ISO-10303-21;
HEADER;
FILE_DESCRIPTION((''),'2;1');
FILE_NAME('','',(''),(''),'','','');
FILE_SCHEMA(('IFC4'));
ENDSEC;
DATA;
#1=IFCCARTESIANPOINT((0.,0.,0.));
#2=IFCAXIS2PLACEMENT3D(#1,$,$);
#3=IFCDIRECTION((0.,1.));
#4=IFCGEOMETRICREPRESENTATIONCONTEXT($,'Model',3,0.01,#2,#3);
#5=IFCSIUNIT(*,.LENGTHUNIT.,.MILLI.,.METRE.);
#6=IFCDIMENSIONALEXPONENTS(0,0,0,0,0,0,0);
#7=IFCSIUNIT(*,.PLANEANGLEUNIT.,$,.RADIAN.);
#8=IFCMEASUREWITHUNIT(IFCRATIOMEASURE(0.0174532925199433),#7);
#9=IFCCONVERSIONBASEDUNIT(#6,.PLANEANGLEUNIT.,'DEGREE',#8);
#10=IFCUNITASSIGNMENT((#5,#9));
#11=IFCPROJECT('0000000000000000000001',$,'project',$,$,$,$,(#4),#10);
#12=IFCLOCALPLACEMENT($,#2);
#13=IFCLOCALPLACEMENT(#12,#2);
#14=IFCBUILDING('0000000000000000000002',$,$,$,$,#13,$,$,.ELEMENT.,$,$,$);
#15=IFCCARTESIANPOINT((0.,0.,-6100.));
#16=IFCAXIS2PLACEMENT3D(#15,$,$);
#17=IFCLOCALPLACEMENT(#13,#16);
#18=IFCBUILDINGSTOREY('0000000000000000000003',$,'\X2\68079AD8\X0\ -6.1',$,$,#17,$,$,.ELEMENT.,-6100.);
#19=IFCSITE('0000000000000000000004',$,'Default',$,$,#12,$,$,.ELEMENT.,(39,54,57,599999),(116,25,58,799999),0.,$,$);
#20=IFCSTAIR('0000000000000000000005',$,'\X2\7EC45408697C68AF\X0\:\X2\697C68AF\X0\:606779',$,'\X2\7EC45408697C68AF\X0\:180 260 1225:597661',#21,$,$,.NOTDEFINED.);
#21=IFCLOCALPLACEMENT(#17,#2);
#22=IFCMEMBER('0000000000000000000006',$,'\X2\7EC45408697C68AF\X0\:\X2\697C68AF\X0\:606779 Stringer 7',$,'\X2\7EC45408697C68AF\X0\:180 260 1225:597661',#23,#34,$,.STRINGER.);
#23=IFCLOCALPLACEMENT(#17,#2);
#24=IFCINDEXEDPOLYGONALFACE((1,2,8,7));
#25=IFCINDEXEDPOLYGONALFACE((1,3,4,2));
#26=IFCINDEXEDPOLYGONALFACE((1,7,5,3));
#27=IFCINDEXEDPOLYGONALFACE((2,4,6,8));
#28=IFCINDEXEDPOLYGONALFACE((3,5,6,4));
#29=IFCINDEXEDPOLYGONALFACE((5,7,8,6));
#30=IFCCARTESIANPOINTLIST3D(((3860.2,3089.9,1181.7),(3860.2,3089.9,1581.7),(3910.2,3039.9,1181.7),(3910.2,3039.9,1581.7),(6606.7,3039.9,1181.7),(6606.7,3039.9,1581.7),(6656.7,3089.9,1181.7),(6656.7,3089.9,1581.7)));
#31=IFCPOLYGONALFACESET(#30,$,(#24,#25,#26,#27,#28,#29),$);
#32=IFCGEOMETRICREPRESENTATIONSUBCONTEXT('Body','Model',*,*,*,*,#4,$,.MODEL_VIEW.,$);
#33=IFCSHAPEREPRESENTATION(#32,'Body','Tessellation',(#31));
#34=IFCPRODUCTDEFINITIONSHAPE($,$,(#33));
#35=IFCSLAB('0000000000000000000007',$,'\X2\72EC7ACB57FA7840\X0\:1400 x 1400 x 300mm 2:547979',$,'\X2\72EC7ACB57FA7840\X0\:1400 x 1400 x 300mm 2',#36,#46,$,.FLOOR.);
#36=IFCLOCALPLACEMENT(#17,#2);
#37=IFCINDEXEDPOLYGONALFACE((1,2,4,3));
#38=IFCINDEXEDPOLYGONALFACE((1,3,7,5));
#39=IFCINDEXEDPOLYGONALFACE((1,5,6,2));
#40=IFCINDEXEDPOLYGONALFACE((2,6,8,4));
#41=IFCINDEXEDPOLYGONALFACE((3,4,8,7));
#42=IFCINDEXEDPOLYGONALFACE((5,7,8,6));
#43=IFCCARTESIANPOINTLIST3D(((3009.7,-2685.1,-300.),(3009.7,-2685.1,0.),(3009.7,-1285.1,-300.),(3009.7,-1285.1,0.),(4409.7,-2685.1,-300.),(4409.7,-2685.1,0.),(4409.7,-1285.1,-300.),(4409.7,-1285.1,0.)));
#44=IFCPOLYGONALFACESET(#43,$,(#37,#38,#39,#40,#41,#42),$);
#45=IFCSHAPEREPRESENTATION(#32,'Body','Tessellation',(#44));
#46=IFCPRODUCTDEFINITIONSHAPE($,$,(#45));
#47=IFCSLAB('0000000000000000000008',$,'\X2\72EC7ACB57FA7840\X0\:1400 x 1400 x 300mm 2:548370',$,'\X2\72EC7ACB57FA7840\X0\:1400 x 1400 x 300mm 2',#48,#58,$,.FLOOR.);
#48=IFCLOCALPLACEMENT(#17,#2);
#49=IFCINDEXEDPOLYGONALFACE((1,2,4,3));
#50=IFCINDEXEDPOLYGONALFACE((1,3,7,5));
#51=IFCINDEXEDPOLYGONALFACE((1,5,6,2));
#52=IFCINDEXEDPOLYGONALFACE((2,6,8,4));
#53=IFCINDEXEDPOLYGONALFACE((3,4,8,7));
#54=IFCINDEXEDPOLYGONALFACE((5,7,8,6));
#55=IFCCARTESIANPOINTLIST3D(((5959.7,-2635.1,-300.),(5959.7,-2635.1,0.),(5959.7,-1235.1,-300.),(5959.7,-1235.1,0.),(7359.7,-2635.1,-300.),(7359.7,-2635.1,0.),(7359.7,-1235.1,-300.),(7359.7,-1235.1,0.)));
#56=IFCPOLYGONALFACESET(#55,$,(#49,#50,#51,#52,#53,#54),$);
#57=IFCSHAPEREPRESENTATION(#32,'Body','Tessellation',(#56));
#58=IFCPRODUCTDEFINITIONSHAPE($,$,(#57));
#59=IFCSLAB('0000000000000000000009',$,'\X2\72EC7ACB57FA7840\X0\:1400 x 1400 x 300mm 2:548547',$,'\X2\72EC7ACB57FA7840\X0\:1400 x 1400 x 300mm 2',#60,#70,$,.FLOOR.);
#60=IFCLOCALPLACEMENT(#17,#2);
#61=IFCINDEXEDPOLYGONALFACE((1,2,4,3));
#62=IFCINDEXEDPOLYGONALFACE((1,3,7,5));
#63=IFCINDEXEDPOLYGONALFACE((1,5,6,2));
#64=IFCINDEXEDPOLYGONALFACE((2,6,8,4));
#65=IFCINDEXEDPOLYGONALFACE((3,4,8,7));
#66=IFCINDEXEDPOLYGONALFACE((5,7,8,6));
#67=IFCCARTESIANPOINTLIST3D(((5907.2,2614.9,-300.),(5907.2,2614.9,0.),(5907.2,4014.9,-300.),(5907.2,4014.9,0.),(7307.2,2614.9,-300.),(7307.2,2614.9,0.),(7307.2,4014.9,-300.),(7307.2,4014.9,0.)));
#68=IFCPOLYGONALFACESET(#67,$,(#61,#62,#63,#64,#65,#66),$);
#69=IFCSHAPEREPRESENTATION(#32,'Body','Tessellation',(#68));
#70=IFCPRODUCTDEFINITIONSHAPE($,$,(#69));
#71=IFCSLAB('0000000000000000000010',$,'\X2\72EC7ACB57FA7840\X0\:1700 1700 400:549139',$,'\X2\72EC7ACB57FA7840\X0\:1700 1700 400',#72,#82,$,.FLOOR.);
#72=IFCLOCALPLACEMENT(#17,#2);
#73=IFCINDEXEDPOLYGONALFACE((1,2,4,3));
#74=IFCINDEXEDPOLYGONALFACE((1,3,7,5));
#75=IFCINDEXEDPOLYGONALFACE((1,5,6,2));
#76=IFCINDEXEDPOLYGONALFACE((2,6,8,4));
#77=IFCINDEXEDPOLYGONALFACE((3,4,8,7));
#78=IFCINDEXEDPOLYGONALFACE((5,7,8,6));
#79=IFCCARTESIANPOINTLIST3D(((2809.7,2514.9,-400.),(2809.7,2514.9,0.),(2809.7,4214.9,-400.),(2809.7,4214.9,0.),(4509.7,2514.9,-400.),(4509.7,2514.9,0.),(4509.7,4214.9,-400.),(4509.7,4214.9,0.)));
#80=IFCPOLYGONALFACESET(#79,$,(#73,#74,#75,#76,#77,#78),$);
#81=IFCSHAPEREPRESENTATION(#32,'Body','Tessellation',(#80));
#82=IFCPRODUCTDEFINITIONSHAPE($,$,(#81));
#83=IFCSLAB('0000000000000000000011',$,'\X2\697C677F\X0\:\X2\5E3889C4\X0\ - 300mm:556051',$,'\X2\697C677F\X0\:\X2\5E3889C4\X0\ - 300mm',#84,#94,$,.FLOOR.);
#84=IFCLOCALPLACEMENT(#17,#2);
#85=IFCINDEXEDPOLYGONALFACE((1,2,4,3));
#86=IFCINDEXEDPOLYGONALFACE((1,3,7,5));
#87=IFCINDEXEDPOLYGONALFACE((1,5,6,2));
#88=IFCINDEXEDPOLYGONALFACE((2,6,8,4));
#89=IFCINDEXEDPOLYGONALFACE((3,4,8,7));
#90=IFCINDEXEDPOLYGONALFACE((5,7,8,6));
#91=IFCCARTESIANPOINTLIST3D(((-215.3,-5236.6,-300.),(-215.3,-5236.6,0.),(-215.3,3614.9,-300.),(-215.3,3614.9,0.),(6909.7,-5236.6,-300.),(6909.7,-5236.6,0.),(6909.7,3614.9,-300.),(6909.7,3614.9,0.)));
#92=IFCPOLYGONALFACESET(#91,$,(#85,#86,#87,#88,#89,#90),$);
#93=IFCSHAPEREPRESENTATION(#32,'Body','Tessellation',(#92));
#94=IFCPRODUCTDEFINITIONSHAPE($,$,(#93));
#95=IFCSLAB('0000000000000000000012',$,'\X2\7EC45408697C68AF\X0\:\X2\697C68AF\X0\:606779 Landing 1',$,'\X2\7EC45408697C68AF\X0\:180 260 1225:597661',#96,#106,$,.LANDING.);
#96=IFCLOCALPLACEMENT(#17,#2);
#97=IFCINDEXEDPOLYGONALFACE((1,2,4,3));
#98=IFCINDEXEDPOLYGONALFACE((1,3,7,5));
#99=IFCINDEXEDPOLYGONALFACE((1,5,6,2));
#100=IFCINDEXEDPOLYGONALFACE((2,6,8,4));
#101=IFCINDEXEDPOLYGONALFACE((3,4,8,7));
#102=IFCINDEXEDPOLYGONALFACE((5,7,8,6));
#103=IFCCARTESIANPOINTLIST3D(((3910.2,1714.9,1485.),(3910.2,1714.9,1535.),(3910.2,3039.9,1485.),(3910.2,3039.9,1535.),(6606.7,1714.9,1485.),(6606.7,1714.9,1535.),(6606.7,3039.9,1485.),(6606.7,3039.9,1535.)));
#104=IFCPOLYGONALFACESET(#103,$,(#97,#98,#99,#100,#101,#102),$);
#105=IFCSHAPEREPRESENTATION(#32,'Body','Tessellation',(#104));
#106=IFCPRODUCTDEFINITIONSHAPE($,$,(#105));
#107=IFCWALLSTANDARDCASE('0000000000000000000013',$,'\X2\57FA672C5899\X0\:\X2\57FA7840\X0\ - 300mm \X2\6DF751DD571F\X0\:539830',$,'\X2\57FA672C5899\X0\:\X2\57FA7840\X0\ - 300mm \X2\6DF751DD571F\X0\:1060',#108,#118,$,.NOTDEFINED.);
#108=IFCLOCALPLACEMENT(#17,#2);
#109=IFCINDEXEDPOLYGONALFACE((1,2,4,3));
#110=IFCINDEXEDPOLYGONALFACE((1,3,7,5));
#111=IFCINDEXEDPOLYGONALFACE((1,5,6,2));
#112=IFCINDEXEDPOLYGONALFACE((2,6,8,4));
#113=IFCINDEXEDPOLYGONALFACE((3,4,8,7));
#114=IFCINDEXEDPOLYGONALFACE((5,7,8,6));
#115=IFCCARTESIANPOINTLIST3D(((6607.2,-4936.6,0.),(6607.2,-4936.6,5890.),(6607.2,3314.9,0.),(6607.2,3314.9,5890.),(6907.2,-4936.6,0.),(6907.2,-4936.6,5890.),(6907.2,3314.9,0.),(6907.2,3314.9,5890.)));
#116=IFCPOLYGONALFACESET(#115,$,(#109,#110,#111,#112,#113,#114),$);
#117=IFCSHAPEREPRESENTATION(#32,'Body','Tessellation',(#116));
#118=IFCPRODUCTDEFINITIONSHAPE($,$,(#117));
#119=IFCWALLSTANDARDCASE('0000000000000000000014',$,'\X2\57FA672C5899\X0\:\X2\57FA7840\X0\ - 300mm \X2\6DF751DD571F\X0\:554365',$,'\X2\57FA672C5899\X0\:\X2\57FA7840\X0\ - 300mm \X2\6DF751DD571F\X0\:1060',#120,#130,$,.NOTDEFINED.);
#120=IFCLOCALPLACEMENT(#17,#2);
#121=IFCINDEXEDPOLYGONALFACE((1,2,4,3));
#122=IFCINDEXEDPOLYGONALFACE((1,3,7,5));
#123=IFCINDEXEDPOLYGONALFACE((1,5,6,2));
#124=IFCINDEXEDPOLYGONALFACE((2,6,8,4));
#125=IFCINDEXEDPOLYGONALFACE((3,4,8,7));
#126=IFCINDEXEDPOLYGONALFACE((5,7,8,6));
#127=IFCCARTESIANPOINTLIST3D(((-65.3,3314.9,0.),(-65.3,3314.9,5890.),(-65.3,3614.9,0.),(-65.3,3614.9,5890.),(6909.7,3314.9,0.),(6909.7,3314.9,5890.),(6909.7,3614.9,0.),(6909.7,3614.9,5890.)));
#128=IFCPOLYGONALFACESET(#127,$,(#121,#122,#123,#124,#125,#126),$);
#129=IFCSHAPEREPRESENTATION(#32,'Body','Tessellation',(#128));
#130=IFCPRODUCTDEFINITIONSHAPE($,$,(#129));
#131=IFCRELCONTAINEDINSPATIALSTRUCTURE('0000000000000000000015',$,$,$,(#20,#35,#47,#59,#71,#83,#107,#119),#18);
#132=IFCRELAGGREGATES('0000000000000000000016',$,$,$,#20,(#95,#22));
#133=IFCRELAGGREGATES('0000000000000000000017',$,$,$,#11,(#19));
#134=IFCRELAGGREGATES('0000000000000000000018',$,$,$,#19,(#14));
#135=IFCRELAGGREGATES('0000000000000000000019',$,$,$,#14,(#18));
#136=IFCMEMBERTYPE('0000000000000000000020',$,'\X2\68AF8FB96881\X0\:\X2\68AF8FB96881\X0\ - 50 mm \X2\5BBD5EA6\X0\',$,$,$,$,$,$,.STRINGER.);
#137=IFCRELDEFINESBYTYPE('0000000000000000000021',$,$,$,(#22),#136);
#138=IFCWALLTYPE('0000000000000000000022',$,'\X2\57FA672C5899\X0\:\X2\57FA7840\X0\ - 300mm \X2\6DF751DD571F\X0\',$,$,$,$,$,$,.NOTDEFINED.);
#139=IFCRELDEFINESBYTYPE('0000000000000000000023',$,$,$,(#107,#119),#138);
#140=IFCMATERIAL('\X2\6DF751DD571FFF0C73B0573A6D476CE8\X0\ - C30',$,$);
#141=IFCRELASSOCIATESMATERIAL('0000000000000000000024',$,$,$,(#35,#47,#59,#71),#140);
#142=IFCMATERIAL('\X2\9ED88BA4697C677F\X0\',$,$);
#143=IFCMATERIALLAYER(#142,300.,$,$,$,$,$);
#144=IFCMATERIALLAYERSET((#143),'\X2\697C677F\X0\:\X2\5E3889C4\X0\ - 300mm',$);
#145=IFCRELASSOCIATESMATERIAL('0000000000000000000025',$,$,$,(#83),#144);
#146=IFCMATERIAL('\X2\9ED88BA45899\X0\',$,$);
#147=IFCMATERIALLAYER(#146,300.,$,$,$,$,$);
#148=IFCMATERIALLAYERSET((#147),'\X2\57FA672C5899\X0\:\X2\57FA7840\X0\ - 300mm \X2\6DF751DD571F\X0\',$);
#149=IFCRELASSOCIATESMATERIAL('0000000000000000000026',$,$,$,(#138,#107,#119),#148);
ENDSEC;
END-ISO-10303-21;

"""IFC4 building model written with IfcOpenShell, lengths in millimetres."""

from ifc_helpers import new_model, entity, si_unit, converted_unit, direction, frame, frame_2d, origin, origin_2d_with_axis, place, context, subcontext, project, spatial, polyline, rectangle, outline, extrude, clip, bounded_halfspace, material, layer, layer_set, layer_usage, type_object, element, aggregate, save


model = new_model("IFC4")

# Units and contexts
model_context = context("Model", 3, precision=0.01, world=origin(), true_north=direction((0.0, 1.0)))
body_context = subcontext(model_context, "Body", "Model", "MODEL_VIEW")
ifc_project = project(units=[si_unit("LENGTHUNIT", "METRE", prefix="MILLI"), converted_unit("PLANEANGLEUNIT", "DEGREE", entity("IfcRatioMeasure", 0.0174532925199433), si_unit("PLANEANGLEUNIT", "RADIAN"), dimensions=[0, 0, 0, 0, 0, 0, 0])], contexts=[model_context])

# Site, building, storey
site_placement = place(None, origin())
site = spatial("IfcSite", under=ifc_project, at=site_placement, Name="Default", CompositionType="ELEMENT", RefLatitude=(39, 54, 57, 599999), RefLongitude=(116, 25, 58, 799999), RefElevation=0.0)
building_placement = place(site_placement, origin())
building = spatial("IfcBuilding", under=site, at=building_placement, CompositionType="ELEMENT")
storey_placement = place(building_placement, frame((0.0, 0.0, -6100.0)))
storey = spatial("IfcBuildingStorey", under=building, at=storey_placement, Name="标高 -6.1", CompositionType="ELEMENT", Elevation=-6100.0)

# Stair, member
stair_placement = place(storey_placement, origin())
stair = element("IfcStair", 1, at=stair_placement, inside=storey, Name="组合楼梯:楼梯:606779", ObjectType="组合楼梯:180 260 1225:597661", PredefinedType="NOTDEFINED")
member_type = type_object("IfcMemberType", Name="梯边梁:梯边梁 - 50 mm 宽度", PredefinedType="STRINGER")
member_1_placement = place(stair_placement, frame((3860.2, 3039.9, 1181.7)))
member_1 = element("IfcMember", 2, at=member_1_placement, type_object=member_type, Name="组合楼梯:楼梯:606779 Stringer 7", ObjectType="组合楼梯:180 260 1225:597661", PredefinedType="STRINGER", context=body_context, shape_type="SweptSolid", body=[
    extrude(outline(polyline([(-1398.3, -25.0), (1398.3, -25.0), (1348.3, 25.0), (-1348.3, 25.0), (-1398.3, -25.0)])), frame((1398.3, 25.0, 0.0), z_axis=(0.0, 0.0, 1.0), x_axis=(-1.0, 0.0, 0.0)), (0.0, 0.0, 1.0), 400.0),
])

# Slabs
ifc_material_1 = material(Name="混凝土，现场浇注 - C30")
for number, where, name in (
    (3, (3009.7, -2685.1, -300.0), "独立基础:1400 x 1400 x 300mm 2:547979"),
    (4, (5959.7, -2635.1, -300.0), "独立基础:1400 x 1400 x 300mm 2:548370"),
    (5, (5907.2, 2614.9, -300.0), "独立基础:1400 x 1400 x 300mm 2:548547"),
):
    element("IfcSlab", number, at=place(storey_placement, frame(where)), inside=storey, material=ifc_material_1, Name=name, ObjectType="独立基础:1400 x 1400 x 300mm 2", PredefinedType="FLOOR", context=body_context, shape_type="SweptSolid", body=[
        extrude(rectangle(XDim=1400.0, YDim=1400.0, at=origin_2d_with_axis()), frame((700.0, 700.0, 0.0), z_axis=(0.0, 0.0, 1.0), x_axis=(-1.0, 0.0, 0.0)), (0.0, 0.0, 1.0), 300.0),
    ])
slab_1_placement = place(storey_placement, frame((2809.7, 2514.9, -400.0)))
element("IfcSlab", 6, at=slab_1_placement, inside=storey, material=ifc_material_1, Name="独立基础:1700 1700 400:549139", ObjectType="独立基础:1700 1700 400", PredefinedType="FLOOR", context=body_context, shape_type="SweptSolid", body=[
    extrude(rectangle(XDim=1700.0, YDim=1700.0, at=frame_2d((0.0, 0.0), x_axis=(1.0, 0.0))), frame((850.0, 850.0, 0.0), z_axis=(0.0, 0.0, 1.0), x_axis=(-1.0, 0.0, 0.0)), (0.0, 0.0, 1.0), 400.0),
])
ifc_material_2 = material(Name="默认楼板")
ifc_layer_1 = layer(ifc_material_2, 300.0)
ifc_layer_set_1 = layer_set([ifc_layer_1], Name="楼板:常规 - 300mm")
ifc_layer_usage_1 = layer_usage(ifc_layer_set_1, "AXIS3", "POSITIVE", 0.0)
slab_2_placement = place(storey_placement, origin())
element("IfcSlab", 7, at=slab_2_placement, inside=storey, material=ifc_layer_usage_1, Name="楼板:常规 - 300mm:556051", ObjectType="楼板:常规 - 300mm", PredefinedType="FLOOR", context=body_context, shape_type="SweptSolid", body=[
    extrude(rectangle(XDim=8851.5, YDim=7125.0, at=origin_2d_with_axis()), frame((3347.2, -810.8, 0.0), z_axis=(0.0, 0.0, -1.0), x_axis=(0.0, 1.0, 0.0)), (0.0, 0.0, 1.0), 300.0),
])

# Slab
slab_3_placement = place(stair_placement, frame((3910.2, 1714.9, 0.0)))
slab_3 = element("IfcSlab", 8, at=slab_3_placement, Name="组合楼梯:楼梯:606779 Landing 1", ObjectType="组合楼梯:180 260 1225:597661", PredefinedType="LANDING", context=body_context, shape_type="SweptSolid", body=[
    extrude(rectangle(XDim=2696.6, YDim=1325.0, at=frame_2d((0.0, 220.8), x_axis=(1.0, 0.0))), frame((1348.3, 441.7, 1485.0)), (0.0, 0.0, 1.0), 50.0),
])

# Walls
ifc_material_3 = material(Name="默认墙")
ifc_layer_2 = layer(ifc_material_3, 300.0)
ifc_layer_set_2 = layer_set([ifc_layer_2], Name="基本墙:基础 - 300mm 混凝土")
ifc_layer_usage_2 = layer_usage(ifc_layer_set_2, "AXIS2", "NEGATIVE", 150.0)
wall_type = type_object("IfcWallType", Name="基本墙:基础 - 300mm 混凝土", PredefinedType="NOTDEFINED", material=ifc_layer_set_2)
wall_1_placement = place(storey_placement, frame((6757.2, -4936.6, 0.0), z_axis=(0.0, 0.0, 1.0), x_axis=(0.0, 1.0, 0.0)))
element("IfcWallStandardCase", 9, at=wall_1_placement, inside=storey, type_object=wall_type, material=ifc_layer_usage_2, Name="基本墙:基础 - 300mm 混凝土:539830", ObjectType="基本墙:基础 - 300mm 混凝土:1060", PredefinedType="NOTDEFINED", context=body_context, shape_type="Clipping", body=[
    clip(extrude(rectangle(XDim=8251.5, YDim=300.0, at=frame_2d((4125.8, 0.0), x_axis=(-1.0, 0.0))), origin(), (0.0, 0.0, 1.0), 5890.0), bounded_halfspace(frame((0.0, -150.0, 5890.0), z_axis=(0.0, 0.0, -1.0), x_axis=(1.0, 0.0, 0.0)), True, frame((0.0, -150.0, 5890.0)), polyline([(0.0, 0.0), (2751.5, 0.0), (3251.5, 0.0), (7951.5, 0.0), (8251.5, 0.0), (8251.5, 300.0), (7951.5, 300.0), (3251.5, 300.0), (2751.5, 300.0), (0.0, 300.0), (0.0, 0.0)]))),
])
ifc_layer_usage_3 = layer_usage(ifc_layer_set_2, "AXIS2", "NEGATIVE", 150.0)
wall_2_placement = place(storey_placement, frame((-65.3, 3464.9, 0.0)))
element("IfcWallStandardCase", 10, at=wall_2_placement, inside=storey, type_object=wall_type, material=ifc_layer_usage_3, Name="基本墙:基础 - 300mm 混凝土:554365", ObjectType="基本墙:基础 - 300mm 混凝土:1060", PredefinedType="NOTDEFINED", context=body_context, shape_type="Clipping", body=[
    clip(extrude(rectangle(XDim=6975.0, YDim=300.0, at=frame_2d((3487.5, 0.0), x_axis=(-1.0, 0.0))), origin(), (0.0, 0.0, 1.0), 5890.0), bounded_halfspace(frame((0.0, -150.0, 5890.0), z_axis=(0.0, 0.0, -1.0), x_axis=(0.0, 1.0, 0.0)), True, frame((0.0, -150.0, 5890.0)), polyline([(0.0, 0.0), (3475.0, 0.0), (3975.0, 0.0), (6375.0, 0.0), (6672.6, 0.0), (6972.6, 0.0), (6975.0, 0.0), (6975.0, 300.0), (0.0, 300.0), (0.0, 0.0)]))),
])

aggregate(stair, [slab_3, member_1])

save(model, "model.ifc")
